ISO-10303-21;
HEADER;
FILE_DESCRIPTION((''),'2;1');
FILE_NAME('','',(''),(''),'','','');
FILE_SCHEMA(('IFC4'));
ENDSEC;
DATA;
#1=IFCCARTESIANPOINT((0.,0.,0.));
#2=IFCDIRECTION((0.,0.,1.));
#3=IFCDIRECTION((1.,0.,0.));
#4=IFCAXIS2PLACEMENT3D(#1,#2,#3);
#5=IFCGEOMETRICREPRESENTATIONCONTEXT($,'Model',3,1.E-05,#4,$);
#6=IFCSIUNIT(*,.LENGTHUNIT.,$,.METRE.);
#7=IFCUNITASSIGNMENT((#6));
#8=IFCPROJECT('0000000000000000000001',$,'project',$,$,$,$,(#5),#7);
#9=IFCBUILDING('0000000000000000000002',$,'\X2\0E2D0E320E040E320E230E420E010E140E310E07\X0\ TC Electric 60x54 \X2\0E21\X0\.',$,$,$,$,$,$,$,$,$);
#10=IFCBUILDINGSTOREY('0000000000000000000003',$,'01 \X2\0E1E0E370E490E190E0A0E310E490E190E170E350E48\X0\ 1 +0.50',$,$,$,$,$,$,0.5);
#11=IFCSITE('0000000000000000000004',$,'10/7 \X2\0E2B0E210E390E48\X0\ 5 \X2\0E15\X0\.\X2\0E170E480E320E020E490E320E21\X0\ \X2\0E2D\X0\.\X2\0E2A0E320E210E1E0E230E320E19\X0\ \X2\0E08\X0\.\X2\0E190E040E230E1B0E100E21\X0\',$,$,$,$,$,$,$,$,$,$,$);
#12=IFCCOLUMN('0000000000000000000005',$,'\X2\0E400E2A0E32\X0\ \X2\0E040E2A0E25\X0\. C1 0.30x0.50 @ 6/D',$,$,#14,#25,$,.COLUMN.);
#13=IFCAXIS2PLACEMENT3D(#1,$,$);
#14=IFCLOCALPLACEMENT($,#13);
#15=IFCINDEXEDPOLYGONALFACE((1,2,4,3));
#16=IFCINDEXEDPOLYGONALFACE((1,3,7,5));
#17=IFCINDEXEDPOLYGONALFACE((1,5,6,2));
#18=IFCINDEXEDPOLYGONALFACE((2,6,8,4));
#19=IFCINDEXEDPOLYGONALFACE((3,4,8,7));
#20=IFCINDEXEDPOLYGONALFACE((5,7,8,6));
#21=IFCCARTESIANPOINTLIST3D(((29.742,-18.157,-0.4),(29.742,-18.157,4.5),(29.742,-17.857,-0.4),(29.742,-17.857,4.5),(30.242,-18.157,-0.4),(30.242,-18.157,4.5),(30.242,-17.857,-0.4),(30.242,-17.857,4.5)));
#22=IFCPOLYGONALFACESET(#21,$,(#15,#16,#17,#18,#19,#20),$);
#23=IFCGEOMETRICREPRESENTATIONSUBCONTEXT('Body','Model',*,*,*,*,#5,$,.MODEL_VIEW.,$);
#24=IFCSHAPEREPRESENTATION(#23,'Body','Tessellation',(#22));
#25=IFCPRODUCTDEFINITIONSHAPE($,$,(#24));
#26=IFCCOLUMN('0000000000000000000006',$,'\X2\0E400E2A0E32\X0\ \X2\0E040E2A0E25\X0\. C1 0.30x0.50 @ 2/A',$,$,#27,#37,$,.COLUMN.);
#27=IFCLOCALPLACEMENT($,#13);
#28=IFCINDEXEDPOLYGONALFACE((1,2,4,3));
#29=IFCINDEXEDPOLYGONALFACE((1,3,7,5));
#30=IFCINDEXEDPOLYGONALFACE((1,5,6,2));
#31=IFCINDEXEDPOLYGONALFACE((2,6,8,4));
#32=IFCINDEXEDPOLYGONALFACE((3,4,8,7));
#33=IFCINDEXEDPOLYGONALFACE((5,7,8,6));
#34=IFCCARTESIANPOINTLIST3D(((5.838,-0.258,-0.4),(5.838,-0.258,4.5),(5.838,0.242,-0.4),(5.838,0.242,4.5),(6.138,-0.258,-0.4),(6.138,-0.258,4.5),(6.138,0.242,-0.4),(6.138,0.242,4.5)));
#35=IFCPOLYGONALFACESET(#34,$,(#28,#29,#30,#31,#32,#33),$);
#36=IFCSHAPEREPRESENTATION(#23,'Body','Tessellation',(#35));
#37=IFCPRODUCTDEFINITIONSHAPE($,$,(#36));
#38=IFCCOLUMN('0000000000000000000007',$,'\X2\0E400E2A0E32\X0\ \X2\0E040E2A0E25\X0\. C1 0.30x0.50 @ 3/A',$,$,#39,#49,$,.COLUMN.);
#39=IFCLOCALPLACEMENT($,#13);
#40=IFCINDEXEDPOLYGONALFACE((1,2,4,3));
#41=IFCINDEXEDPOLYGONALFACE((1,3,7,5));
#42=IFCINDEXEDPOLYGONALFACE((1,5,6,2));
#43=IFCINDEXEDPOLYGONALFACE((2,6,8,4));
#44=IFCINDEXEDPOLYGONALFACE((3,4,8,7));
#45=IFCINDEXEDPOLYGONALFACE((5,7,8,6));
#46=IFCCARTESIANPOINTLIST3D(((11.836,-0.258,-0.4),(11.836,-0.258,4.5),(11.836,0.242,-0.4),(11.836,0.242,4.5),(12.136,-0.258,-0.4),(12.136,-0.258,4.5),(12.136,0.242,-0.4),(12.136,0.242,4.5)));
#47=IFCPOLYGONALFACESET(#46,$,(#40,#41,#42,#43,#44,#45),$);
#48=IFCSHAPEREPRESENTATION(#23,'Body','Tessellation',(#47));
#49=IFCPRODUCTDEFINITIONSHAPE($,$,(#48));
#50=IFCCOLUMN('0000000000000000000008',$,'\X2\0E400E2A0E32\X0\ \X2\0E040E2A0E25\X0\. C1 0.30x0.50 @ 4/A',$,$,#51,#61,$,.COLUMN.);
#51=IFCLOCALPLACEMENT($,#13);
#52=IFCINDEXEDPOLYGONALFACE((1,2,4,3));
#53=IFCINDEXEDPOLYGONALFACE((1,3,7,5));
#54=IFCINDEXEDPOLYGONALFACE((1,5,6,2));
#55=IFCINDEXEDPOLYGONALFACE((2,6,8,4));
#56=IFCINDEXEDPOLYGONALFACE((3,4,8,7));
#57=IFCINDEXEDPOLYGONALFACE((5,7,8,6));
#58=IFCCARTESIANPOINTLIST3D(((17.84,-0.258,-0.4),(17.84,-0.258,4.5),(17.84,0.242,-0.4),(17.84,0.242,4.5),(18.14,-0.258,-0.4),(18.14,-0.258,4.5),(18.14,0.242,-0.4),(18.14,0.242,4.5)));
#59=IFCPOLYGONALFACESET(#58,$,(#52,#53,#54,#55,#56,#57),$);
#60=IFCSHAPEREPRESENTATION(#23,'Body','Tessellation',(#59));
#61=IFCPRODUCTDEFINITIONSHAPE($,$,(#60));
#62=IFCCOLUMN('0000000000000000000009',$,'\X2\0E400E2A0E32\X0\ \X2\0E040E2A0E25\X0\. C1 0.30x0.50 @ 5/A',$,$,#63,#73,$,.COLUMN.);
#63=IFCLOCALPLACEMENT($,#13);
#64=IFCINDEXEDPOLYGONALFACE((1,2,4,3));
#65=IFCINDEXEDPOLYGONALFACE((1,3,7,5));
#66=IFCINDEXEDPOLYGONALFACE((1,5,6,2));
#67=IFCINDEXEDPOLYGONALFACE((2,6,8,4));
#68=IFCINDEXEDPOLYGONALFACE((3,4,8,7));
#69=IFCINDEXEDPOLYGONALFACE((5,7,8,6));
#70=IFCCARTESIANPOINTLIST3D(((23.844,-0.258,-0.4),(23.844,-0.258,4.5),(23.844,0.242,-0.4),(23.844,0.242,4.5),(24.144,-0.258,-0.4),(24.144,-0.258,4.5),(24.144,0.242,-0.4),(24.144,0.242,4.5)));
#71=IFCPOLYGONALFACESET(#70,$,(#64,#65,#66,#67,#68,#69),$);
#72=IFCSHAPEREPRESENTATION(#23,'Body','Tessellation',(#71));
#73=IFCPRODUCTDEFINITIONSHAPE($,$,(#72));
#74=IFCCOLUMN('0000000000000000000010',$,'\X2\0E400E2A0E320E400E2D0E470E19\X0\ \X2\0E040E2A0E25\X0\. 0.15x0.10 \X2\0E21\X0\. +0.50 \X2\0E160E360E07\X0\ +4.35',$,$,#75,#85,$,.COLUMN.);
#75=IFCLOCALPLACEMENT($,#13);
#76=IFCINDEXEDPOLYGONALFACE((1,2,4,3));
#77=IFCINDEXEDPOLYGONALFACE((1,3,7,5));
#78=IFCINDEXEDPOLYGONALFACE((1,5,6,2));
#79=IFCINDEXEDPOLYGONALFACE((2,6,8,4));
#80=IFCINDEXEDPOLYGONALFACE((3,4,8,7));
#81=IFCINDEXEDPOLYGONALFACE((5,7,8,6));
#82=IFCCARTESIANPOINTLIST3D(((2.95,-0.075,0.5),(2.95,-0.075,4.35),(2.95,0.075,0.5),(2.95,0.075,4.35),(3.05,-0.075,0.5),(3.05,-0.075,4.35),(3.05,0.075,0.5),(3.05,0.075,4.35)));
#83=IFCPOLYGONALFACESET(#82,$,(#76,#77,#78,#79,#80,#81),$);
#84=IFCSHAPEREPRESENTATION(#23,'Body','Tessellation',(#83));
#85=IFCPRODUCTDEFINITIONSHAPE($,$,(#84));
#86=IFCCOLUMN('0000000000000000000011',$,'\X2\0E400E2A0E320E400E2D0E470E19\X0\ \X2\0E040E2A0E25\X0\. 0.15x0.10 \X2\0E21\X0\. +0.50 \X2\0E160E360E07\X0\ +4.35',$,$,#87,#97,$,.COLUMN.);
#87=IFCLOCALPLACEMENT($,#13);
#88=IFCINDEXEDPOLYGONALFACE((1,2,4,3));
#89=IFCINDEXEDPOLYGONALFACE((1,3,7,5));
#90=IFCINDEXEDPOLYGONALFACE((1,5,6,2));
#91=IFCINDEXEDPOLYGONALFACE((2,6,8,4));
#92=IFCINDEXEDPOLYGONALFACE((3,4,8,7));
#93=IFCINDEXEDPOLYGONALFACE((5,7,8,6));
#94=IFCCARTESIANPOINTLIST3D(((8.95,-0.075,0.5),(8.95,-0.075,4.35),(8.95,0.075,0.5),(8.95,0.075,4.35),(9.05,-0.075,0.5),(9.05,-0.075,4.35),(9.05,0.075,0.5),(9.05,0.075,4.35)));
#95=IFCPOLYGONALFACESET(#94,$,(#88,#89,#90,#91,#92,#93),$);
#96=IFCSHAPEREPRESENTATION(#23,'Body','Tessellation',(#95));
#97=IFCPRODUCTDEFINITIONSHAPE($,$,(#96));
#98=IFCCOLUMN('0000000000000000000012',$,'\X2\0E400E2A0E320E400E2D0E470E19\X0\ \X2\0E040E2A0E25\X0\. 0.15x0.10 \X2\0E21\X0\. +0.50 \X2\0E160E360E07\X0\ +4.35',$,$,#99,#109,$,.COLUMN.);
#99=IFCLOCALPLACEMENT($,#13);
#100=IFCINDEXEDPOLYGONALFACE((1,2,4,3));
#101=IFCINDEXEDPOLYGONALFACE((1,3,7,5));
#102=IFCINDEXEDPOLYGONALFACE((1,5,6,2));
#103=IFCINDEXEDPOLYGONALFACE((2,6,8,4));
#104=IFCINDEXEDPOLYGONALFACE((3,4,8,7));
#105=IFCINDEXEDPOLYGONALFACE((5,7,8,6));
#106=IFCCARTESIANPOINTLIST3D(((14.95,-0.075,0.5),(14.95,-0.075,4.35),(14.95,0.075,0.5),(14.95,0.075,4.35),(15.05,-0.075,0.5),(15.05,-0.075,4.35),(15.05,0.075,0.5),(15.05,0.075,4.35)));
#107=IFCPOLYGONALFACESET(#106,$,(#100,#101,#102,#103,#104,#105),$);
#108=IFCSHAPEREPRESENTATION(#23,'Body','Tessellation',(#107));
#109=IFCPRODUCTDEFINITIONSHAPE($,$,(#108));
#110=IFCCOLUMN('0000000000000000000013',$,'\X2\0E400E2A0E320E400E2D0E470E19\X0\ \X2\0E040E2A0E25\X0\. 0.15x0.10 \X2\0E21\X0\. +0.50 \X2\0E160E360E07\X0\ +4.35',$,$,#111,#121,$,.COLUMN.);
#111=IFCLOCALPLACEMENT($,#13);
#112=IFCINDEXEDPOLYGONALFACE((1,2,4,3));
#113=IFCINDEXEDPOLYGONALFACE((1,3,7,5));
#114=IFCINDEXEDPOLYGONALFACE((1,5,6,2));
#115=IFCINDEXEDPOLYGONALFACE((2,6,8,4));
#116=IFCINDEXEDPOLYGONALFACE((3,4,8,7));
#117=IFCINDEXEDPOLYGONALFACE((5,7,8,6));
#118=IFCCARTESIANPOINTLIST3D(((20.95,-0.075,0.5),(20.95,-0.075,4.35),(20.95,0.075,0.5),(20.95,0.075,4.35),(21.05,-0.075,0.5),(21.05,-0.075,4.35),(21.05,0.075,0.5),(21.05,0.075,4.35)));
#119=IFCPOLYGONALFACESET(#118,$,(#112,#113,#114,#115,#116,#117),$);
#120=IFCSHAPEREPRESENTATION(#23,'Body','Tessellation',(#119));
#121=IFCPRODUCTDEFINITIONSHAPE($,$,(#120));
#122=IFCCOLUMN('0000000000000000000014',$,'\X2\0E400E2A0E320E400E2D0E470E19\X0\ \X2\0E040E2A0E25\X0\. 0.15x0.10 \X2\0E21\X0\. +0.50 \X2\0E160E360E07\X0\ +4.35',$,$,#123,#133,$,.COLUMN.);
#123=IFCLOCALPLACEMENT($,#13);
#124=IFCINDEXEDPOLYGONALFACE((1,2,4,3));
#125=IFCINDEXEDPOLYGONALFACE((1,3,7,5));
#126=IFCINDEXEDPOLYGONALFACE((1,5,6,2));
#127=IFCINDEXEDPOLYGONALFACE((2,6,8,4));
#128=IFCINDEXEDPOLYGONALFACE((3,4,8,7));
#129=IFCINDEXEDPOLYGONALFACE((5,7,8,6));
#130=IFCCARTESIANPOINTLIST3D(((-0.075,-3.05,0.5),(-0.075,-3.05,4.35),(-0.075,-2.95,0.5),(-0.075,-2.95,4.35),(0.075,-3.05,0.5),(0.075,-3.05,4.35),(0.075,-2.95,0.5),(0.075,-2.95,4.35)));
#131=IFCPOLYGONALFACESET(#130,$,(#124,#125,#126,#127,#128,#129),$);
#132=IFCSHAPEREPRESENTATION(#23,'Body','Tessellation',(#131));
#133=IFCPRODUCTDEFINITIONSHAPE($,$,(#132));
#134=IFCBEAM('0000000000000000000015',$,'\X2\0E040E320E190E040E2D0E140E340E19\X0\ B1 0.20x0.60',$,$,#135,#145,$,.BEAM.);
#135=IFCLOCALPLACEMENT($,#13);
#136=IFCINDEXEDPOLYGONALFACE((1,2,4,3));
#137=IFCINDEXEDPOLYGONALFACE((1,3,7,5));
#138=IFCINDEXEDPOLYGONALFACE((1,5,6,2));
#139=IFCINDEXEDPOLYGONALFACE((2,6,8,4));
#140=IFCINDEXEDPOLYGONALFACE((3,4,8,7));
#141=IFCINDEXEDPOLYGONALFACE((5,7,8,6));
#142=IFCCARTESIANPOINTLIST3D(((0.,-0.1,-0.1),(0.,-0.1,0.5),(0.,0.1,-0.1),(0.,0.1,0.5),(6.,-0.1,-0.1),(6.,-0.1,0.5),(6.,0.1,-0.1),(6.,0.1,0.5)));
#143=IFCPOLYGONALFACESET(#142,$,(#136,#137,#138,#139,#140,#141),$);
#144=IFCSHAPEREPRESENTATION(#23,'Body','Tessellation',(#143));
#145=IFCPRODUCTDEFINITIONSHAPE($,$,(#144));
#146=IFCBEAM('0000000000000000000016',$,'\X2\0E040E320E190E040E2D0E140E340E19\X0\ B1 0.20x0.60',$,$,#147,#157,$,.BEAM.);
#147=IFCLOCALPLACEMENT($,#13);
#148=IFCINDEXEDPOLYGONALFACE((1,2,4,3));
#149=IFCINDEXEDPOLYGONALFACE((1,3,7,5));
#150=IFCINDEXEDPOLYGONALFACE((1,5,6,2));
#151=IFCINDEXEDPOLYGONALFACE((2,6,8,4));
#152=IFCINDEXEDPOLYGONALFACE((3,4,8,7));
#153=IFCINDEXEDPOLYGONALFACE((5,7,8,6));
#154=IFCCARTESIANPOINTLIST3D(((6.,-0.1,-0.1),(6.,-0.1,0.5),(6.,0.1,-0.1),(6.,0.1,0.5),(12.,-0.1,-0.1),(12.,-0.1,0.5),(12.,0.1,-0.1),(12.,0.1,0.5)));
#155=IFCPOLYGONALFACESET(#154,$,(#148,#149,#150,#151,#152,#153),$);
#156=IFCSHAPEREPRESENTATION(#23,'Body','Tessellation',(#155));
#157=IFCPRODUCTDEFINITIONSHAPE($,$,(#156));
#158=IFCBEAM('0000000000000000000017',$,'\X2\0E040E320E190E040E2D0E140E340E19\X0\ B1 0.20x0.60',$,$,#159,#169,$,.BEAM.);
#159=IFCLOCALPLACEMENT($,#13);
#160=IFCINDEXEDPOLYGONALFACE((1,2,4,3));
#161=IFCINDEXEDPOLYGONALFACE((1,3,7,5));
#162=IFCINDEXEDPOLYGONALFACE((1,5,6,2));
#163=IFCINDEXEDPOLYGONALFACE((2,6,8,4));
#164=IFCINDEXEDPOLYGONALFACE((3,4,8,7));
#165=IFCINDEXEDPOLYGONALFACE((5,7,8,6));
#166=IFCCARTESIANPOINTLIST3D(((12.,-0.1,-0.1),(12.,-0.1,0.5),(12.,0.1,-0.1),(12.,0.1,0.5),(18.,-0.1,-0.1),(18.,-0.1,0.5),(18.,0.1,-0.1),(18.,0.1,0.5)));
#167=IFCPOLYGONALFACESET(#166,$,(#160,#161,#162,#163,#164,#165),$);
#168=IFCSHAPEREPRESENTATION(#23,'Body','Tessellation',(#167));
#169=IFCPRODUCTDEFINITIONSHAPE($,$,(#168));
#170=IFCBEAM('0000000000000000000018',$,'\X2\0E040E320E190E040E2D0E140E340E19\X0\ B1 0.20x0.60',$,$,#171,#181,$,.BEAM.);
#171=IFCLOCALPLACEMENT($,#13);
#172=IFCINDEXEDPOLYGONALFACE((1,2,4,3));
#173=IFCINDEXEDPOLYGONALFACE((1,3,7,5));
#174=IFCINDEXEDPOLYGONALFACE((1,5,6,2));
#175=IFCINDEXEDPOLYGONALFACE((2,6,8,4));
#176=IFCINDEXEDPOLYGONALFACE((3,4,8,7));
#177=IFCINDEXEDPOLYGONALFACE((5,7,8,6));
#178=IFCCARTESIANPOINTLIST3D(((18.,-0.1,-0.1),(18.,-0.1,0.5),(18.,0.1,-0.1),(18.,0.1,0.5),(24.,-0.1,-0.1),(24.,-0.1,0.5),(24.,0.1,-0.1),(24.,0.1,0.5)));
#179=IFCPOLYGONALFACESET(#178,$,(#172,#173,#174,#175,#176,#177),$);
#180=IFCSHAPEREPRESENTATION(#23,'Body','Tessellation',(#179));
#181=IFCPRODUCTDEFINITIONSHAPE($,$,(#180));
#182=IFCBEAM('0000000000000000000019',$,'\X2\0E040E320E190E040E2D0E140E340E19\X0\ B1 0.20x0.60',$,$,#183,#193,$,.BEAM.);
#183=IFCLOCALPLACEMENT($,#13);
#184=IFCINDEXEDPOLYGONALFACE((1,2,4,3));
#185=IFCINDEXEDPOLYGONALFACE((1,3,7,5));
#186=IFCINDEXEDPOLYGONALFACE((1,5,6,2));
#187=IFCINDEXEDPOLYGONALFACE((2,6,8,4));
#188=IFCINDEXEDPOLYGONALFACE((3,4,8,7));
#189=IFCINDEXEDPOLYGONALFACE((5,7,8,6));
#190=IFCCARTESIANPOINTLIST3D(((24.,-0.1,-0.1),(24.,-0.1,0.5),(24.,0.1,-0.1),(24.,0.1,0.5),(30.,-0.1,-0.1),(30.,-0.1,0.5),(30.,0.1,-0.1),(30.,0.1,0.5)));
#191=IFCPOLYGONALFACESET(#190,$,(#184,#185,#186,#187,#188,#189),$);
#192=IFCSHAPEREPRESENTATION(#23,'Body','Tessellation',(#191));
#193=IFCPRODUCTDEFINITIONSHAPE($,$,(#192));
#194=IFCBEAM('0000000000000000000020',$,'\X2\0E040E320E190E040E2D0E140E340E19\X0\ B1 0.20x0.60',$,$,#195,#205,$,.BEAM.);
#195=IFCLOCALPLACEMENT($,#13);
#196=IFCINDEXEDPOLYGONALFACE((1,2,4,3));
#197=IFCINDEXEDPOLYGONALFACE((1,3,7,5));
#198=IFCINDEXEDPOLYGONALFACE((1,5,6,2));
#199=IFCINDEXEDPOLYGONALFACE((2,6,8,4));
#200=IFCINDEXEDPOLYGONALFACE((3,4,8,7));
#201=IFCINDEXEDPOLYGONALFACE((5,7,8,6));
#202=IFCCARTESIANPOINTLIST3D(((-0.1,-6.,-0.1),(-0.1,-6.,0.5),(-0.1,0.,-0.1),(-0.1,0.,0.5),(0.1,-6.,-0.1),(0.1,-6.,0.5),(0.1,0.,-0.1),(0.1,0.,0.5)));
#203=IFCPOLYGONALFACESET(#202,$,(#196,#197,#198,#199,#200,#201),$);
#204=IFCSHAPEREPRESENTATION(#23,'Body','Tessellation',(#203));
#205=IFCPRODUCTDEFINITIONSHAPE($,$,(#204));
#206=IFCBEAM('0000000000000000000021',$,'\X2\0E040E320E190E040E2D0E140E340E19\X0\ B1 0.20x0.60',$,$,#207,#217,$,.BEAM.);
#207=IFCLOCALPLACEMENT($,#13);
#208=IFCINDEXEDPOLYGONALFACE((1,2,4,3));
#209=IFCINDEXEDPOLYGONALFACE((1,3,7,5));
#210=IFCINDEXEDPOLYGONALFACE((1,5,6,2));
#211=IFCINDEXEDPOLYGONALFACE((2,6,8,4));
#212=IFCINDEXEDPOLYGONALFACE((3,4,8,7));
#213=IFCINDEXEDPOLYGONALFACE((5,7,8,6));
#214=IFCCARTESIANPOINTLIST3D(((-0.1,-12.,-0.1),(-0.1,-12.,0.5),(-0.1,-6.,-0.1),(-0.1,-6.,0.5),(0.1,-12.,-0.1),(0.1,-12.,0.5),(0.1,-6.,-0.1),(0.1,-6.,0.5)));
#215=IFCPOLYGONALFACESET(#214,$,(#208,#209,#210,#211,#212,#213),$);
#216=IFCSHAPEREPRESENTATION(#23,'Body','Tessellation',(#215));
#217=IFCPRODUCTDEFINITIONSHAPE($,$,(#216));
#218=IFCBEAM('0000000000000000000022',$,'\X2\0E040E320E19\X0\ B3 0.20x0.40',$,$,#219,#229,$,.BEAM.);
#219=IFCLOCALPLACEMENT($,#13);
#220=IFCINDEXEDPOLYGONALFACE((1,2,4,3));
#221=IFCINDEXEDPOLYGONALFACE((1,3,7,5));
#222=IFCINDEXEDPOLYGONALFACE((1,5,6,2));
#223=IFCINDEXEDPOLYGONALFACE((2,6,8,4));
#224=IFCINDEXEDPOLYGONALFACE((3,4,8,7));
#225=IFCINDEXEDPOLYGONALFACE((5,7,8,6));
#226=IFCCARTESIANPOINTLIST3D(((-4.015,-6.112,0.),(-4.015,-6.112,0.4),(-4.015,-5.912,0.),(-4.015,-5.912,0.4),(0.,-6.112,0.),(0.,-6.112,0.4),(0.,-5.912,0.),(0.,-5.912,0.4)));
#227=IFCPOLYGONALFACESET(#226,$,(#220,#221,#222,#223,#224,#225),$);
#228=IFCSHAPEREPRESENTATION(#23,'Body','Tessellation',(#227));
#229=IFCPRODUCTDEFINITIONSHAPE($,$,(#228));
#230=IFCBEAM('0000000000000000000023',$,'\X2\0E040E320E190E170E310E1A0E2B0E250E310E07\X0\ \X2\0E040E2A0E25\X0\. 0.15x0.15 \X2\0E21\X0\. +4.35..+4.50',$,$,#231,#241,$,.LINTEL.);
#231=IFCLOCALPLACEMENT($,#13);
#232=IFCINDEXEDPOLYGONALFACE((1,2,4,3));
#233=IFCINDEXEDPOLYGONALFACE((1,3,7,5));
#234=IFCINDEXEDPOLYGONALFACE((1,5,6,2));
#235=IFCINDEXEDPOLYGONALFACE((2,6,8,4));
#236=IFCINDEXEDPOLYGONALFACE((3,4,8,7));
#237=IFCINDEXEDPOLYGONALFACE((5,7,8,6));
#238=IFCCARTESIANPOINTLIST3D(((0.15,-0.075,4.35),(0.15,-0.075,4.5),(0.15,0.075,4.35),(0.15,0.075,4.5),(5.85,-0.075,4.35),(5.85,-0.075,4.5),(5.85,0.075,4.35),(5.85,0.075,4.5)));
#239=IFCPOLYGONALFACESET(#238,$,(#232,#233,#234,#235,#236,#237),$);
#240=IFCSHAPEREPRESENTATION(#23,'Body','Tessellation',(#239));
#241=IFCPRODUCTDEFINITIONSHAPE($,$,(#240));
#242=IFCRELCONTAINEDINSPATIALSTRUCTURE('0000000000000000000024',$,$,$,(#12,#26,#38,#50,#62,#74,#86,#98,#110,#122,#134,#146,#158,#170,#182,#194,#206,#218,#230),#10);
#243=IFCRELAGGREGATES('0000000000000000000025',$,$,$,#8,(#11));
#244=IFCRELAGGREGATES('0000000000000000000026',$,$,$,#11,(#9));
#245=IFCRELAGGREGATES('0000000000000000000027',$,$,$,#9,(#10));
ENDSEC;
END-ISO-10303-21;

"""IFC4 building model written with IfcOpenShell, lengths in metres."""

from ifc_helpers import new_model, si_unit, frame, origin, origin_with_axes, origin_2d, place, context, subcontext, project, spatial, rectangle, extrude, element, save


model = new_model("IFC4")

# Units and contexts
model_context = context("Model", 3, precision=1e-05, world=origin_with_axes())
body_context = subcontext(model_context, "Body", "Model", "MODEL_VIEW")
ifc_project = project(units=[si_unit("LENGTHUNIT", "METRE")], contexts=[model_context])

# Site, building, storey
site = spatial("IfcSite", under=ifc_project, Name="10/7 หมู่ 5 ต.ท่าข้าม อ.สามพราน จ.นครปฐม")
building = spatial("IfcBuilding", under=site, Name="อาคารโกดัง TC Electric 60x54 ม.")
storey = spatial("IfcBuildingStorey", under=building, Name="01 พื้นชั้นที่ 1 +0.50", Elevation=0.5)

# Columns
column_1_placement = place(None, frame((29.992, -18.007, -0.4), z_axis=(0.0, 0.0, 1.0), x_axis=(1.0, 0.0, 0.0)))
element("IfcColumn", 1, at=column_1_placement, inside=storey, Name="เสา คสล. C1 0.30x0.50 @ 6/D", PredefinedType="COLUMN", context=body_context, shape_type="SweptSolid", body=[
    extrude(rectangle(XDim=0.5, YDim=0.3, at=origin_2d()), origin(), (0.0, 0.0, 1.0), 4.9),
])
for number, where, z_axis, x_axis, name in (
    (2, (5.988, -0.008, -0.4), (0.0, 0.0, 1.0), (1.0, 0.0, 0.0), "เสา คสล. C1 0.30x0.50 @ 2/A"),
    (3, (11.986, -0.008, -0.4), (0.0, 0.0, 1.0), (1.0, 0.0, 0.0), "เสา คสล. C1 0.30x0.50 @ 3/A"),
    (4, (17.99, -0.008, -0.4), (0.0, 0.0, 1.0), (1.0, 0.0, 0.0), "เสา คสล. C1 0.30x0.50 @ 4/A"),
    (5, (23.994, -0.008, -0.4), (0.0, 0.0, 1.0), (1.0, 0.0, 0.0), "เสา คสล. C1 0.30x0.50 @ 5/A"),
):
    element("IfcColumn", number, at=place(None, frame(where, z_axis=z_axis, x_axis=x_axis)), inside=storey, Name=name, PredefinedType="COLUMN", context=body_context, shape_type="SweptSolid", body=[
        extrude(rectangle(XDim=0.3, YDim=0.5, at=origin_2d()), origin(), (0.0, 0.0, 1.0), 4.9),
    ])
for number, where, z_axis, x_axis, name in (
    (6, (3.0, 0.0, 0.5), (0.0, 0.0, 1.0), (1.0, 0.0, 0.0), "เสาเอ็น คสล. 0.15x0.10 ม. +0.50 ถึง +4.35"),
    (7, (9.0, 0.0, 0.5), (0.0, 0.0, 1.0), (1.0, 0.0, 0.0), "เสาเอ็น คสล. 0.15x0.10 ม. +0.50 ถึง +4.35"),
    (8, (15.0, 0.0, 0.5), (0.0, 0.0, 1.0), (1.0, 0.0, 0.0), "เสาเอ็น คสล. 0.15x0.10 ม. +0.50 ถึง +4.35"),
    (9, (21.0, 0.0, 0.5), (0.0, 0.0, 1.0), (1.0, 0.0, 0.0), "เสาเอ็น คสล. 0.15x0.10 ม. +0.50 ถึง +4.35"),
):
    element("IfcColumn", number, at=place(None, frame(where, z_axis=z_axis, x_axis=x_axis)), inside=storey, Name=name, PredefinedType="COLUMN", context=body_context, shape_type="SweptSolid", body=[
        extrude(rectangle(XDim=0.1, YDim=0.15, at=origin_2d()), origin(), (0.0, 0.0, 1.0), 3.85),
    ])
column_2_placement = place(None, frame((0.0, -3.0, 0.5), z_axis=(0.0, 0.0, 1.0), x_axis=(1.0, 0.0, 0.0)))
element("IfcColumn", 10, at=column_2_placement, inside=storey, Name="เสาเอ็น คสล. 0.15x0.10 ม. +0.50 ถึง +4.35", PredefinedType="COLUMN", context=body_context, shape_type="SweptSolid", body=[
    extrude(rectangle(XDim=0.15, YDim=0.1, at=origin_2d()), origin(), (0.0, 0.0, 1.0), 3.85),
])

# Beams
for number, where, z_axis, x_axis, name in (
    (11, (0.0, 0.0, 0.2), (1.0, 0.0, 0.0), (0.0, -1.0, 0.0), "คานคอดิน B1 0.20x0.60"),
    (12, (6.0, 0.0, 0.2), (1.0, 0.0, 0.0), (0.0, -1.0, 0.0), "คานคอดิน B1 0.20x0.60"),
    (13, (12.0, 0.0, 0.2), (1.0, 0.0, 0.0), (0.0, -1.0, 0.0), "คานคอดิน B1 0.20x0.60"),
    (14, (18.0, 0.0, 0.2), (1.0, 0.0, 0.0), (0.0, -1.0, 0.0), "คานคอดิน B1 0.20x0.60"),
    (15, (24.0, 0.0, 0.2), (1.0, 0.0, 0.0), (0.0, -1.0, 0.0), "คานคอดิน B1 0.20x0.60"),
    (16, (0.0, 0.0, 0.2), (0.0, -1.0, 0.0), (-1.0, 0.0, 0.0), "คานคอดิน B1 0.20x0.60"),
    (17, (0.0, -6.0, 0.2), (0.0, -1.0, 0.0), (-1.0, 0.0, 0.0), "คานคอดิน B1 0.20x0.60"),
):
    element("IfcBeam", number, at=place(None, frame(where, z_axis=z_axis, x_axis=x_axis)), inside=storey, Name=name, PredefinedType="BEAM", context=body_context, shape_type="SweptSolid", body=[
        extrude(rectangle(XDim=0.2, YDim=0.6, at=origin_2d()), origin(), (0.0, 0.0, 1.0), 6.0),
    ])
beam_1_placement = place(None, frame((0.0, -6.012, 0.2), z_axis=(-1.0, 0.0, 0.0), x_axis=(0.0, 1.0, 0.0)))
element("IfcBeam", 18, at=beam_1_placement, inside=storey, Name="คาน B3 0.20x0.40", PredefinedType="BEAM", context=body_context, shape_type="SweptSolid", body=[
    extrude(rectangle(XDim=0.2, YDim=0.4, at=origin_2d()), origin(), (0.0, 0.0, 1.0), 4.015),
])
beam_2_placement = place(None, frame((0.15, 0.0, 4.425), z_axis=(1.0, 0.0, 0.0), x_axis=(0.0, -1.0, 0.0)))
element("IfcBeam", 19, at=beam_2_placement, inside=storey, Name="คานทับหลัง คสล. 0.15x0.15 ม. +4.35..+4.50", PredefinedType="LINTEL", context=body_context, shape_type="SweptSolid", body=[
    extrude(rectangle(XDim=0.15, YDim=0.15, at=origin_2d()), origin(), (0.0, 0.0, 1.0), 5.7),
])

save(model, "model.ifc")
